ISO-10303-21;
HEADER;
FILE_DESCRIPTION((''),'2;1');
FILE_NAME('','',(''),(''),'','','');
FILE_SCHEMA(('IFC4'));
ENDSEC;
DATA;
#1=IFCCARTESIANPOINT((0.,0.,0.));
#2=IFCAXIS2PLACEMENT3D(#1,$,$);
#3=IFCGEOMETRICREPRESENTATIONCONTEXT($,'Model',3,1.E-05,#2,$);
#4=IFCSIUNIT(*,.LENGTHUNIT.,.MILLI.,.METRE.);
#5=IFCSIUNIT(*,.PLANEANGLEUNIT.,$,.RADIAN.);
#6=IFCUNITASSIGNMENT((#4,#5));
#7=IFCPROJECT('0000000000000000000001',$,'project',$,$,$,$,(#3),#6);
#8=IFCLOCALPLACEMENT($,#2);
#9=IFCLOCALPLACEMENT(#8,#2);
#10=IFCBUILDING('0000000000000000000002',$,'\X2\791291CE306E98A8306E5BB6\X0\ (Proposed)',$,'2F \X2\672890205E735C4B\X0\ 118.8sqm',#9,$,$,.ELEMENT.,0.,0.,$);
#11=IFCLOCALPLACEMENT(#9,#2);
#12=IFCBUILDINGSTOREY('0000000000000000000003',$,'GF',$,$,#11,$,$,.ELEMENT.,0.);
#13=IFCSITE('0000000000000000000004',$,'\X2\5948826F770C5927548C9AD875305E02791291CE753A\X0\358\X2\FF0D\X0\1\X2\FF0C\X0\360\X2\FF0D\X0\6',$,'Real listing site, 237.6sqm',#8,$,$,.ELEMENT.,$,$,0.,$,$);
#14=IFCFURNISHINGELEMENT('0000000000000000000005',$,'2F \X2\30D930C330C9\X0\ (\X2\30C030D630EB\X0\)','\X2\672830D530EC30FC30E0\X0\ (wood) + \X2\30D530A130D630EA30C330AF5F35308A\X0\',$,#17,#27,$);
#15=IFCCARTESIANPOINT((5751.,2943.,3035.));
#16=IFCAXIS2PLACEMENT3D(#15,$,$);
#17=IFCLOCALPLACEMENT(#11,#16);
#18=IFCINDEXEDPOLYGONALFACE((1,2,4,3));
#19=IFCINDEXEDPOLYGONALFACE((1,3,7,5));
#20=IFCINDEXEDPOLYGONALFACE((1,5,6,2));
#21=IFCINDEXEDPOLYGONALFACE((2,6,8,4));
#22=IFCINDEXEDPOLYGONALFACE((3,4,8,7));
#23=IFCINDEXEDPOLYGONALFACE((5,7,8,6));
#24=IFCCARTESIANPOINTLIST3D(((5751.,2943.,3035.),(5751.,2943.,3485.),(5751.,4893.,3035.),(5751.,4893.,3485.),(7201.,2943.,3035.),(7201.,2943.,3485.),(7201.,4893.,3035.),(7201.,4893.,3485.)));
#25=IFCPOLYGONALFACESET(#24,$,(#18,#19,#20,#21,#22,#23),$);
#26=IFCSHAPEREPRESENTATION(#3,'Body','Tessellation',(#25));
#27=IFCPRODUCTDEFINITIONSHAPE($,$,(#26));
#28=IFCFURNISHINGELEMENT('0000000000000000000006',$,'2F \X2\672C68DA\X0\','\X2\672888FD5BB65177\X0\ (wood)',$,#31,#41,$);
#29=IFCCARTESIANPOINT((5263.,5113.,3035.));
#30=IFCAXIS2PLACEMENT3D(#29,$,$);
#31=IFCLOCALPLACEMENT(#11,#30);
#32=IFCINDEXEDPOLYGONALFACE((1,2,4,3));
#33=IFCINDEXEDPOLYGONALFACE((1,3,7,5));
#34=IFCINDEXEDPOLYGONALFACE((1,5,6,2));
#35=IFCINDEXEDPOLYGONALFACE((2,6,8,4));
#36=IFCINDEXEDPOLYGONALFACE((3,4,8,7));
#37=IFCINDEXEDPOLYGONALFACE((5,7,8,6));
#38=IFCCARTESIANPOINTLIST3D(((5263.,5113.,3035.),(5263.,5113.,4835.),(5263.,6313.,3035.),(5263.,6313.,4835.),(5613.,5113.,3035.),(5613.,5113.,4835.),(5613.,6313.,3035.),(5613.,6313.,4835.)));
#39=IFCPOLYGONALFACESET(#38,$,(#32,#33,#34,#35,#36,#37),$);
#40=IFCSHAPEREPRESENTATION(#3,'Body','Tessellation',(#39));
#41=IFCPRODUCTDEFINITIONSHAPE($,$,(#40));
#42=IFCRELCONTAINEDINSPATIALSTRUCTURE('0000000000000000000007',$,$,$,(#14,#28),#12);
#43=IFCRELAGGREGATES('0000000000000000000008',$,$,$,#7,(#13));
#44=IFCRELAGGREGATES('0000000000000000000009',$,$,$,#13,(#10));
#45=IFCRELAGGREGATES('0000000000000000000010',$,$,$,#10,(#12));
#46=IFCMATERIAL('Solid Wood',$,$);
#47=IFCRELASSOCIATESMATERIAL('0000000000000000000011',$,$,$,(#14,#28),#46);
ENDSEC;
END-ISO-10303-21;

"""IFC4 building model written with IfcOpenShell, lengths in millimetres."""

from ifc_helpers import new_model, si_unit, frame, frame_2d, origin, place, context, project, spatial, rectangle, extrude, material, element, save


model = new_model("IFC4")

# Units and contexts
model_context = context("Model", 3, precision=1e-05, world=origin())
ifc_project = project(units=[si_unit("LENGTHUNIT", "METRE", prefix="MILLI"), si_unit("PLANEANGLEUNIT", "RADIAN")], contexts=[model_context])

# Site, building, storey
site_placement = place(None, origin())
site = spatial("IfcSite", under=ifc_project, at=site_placement, Name="奈良県大和高田市礒野町358－1，360－6", ObjectType="Real listing site, 237.6sqm", CompositionType="ELEMENT", RefElevation=0.0)
building_placement = place(site_placement, origin())
building = spatial("IfcBuilding", under=site, at=building_placement, Name="礒野の風の家 (Proposed)", ObjectType="2F 木造平屋 118.8sqm", CompositionType="ELEMENT", ElevationOfRefHeight=0.0, ElevationOfTerrain=0.0)
storey_placement = place(building_placement, origin())
storey = spatial("IfcBuildingStorey", under=building, at=storey_placement, Name="GF", CompositionType="ELEMENT", Elevation=0.0)

# Shared definitions
ifc_material_1 = material(Name="Solid Wood")

# Furnishing elements
furnishing_1_placement = place(storey_placement, frame((5751.0, 2943.0, 3035.0)))
element("IfcFurnishingElement", 1, at=furnishing_1_placement, inside=storey, material=ifc_material_1, Name="2F ベッド (ダブル)", Description="木フレーム (wood) + ファブリック張り", context=model_context, shape_type="SweptSolid", body=[
    extrude(rectangle(XDim=1450.0, YDim=1950.0, at=frame_2d((725.0, 975.0))), frame((5751.0, 2943.0, 3035.0)), (0.0, 0.0, 1.0), 450.0),
])
furnishing_2_placement = place(storey_placement, frame((5263.0, 5113.0, 3035.0)))
element("IfcFurnishingElement", 2, at=furnishing_2_placement, inside=storey, material=ifc_material_1, Name="2F 本棚", Description="木製家具 (wood)", context=model_context, shape_type="SweptSolid", body=[
    extrude(rectangle(XDim=350.0, YDim=1200.0, at=frame_2d((175.0, 600.0))), frame((5263.0, 5113.0, 3035.0)), (0.0, 0.0, 1.0), 1800.0),
])

save(model, "model.ifc")
